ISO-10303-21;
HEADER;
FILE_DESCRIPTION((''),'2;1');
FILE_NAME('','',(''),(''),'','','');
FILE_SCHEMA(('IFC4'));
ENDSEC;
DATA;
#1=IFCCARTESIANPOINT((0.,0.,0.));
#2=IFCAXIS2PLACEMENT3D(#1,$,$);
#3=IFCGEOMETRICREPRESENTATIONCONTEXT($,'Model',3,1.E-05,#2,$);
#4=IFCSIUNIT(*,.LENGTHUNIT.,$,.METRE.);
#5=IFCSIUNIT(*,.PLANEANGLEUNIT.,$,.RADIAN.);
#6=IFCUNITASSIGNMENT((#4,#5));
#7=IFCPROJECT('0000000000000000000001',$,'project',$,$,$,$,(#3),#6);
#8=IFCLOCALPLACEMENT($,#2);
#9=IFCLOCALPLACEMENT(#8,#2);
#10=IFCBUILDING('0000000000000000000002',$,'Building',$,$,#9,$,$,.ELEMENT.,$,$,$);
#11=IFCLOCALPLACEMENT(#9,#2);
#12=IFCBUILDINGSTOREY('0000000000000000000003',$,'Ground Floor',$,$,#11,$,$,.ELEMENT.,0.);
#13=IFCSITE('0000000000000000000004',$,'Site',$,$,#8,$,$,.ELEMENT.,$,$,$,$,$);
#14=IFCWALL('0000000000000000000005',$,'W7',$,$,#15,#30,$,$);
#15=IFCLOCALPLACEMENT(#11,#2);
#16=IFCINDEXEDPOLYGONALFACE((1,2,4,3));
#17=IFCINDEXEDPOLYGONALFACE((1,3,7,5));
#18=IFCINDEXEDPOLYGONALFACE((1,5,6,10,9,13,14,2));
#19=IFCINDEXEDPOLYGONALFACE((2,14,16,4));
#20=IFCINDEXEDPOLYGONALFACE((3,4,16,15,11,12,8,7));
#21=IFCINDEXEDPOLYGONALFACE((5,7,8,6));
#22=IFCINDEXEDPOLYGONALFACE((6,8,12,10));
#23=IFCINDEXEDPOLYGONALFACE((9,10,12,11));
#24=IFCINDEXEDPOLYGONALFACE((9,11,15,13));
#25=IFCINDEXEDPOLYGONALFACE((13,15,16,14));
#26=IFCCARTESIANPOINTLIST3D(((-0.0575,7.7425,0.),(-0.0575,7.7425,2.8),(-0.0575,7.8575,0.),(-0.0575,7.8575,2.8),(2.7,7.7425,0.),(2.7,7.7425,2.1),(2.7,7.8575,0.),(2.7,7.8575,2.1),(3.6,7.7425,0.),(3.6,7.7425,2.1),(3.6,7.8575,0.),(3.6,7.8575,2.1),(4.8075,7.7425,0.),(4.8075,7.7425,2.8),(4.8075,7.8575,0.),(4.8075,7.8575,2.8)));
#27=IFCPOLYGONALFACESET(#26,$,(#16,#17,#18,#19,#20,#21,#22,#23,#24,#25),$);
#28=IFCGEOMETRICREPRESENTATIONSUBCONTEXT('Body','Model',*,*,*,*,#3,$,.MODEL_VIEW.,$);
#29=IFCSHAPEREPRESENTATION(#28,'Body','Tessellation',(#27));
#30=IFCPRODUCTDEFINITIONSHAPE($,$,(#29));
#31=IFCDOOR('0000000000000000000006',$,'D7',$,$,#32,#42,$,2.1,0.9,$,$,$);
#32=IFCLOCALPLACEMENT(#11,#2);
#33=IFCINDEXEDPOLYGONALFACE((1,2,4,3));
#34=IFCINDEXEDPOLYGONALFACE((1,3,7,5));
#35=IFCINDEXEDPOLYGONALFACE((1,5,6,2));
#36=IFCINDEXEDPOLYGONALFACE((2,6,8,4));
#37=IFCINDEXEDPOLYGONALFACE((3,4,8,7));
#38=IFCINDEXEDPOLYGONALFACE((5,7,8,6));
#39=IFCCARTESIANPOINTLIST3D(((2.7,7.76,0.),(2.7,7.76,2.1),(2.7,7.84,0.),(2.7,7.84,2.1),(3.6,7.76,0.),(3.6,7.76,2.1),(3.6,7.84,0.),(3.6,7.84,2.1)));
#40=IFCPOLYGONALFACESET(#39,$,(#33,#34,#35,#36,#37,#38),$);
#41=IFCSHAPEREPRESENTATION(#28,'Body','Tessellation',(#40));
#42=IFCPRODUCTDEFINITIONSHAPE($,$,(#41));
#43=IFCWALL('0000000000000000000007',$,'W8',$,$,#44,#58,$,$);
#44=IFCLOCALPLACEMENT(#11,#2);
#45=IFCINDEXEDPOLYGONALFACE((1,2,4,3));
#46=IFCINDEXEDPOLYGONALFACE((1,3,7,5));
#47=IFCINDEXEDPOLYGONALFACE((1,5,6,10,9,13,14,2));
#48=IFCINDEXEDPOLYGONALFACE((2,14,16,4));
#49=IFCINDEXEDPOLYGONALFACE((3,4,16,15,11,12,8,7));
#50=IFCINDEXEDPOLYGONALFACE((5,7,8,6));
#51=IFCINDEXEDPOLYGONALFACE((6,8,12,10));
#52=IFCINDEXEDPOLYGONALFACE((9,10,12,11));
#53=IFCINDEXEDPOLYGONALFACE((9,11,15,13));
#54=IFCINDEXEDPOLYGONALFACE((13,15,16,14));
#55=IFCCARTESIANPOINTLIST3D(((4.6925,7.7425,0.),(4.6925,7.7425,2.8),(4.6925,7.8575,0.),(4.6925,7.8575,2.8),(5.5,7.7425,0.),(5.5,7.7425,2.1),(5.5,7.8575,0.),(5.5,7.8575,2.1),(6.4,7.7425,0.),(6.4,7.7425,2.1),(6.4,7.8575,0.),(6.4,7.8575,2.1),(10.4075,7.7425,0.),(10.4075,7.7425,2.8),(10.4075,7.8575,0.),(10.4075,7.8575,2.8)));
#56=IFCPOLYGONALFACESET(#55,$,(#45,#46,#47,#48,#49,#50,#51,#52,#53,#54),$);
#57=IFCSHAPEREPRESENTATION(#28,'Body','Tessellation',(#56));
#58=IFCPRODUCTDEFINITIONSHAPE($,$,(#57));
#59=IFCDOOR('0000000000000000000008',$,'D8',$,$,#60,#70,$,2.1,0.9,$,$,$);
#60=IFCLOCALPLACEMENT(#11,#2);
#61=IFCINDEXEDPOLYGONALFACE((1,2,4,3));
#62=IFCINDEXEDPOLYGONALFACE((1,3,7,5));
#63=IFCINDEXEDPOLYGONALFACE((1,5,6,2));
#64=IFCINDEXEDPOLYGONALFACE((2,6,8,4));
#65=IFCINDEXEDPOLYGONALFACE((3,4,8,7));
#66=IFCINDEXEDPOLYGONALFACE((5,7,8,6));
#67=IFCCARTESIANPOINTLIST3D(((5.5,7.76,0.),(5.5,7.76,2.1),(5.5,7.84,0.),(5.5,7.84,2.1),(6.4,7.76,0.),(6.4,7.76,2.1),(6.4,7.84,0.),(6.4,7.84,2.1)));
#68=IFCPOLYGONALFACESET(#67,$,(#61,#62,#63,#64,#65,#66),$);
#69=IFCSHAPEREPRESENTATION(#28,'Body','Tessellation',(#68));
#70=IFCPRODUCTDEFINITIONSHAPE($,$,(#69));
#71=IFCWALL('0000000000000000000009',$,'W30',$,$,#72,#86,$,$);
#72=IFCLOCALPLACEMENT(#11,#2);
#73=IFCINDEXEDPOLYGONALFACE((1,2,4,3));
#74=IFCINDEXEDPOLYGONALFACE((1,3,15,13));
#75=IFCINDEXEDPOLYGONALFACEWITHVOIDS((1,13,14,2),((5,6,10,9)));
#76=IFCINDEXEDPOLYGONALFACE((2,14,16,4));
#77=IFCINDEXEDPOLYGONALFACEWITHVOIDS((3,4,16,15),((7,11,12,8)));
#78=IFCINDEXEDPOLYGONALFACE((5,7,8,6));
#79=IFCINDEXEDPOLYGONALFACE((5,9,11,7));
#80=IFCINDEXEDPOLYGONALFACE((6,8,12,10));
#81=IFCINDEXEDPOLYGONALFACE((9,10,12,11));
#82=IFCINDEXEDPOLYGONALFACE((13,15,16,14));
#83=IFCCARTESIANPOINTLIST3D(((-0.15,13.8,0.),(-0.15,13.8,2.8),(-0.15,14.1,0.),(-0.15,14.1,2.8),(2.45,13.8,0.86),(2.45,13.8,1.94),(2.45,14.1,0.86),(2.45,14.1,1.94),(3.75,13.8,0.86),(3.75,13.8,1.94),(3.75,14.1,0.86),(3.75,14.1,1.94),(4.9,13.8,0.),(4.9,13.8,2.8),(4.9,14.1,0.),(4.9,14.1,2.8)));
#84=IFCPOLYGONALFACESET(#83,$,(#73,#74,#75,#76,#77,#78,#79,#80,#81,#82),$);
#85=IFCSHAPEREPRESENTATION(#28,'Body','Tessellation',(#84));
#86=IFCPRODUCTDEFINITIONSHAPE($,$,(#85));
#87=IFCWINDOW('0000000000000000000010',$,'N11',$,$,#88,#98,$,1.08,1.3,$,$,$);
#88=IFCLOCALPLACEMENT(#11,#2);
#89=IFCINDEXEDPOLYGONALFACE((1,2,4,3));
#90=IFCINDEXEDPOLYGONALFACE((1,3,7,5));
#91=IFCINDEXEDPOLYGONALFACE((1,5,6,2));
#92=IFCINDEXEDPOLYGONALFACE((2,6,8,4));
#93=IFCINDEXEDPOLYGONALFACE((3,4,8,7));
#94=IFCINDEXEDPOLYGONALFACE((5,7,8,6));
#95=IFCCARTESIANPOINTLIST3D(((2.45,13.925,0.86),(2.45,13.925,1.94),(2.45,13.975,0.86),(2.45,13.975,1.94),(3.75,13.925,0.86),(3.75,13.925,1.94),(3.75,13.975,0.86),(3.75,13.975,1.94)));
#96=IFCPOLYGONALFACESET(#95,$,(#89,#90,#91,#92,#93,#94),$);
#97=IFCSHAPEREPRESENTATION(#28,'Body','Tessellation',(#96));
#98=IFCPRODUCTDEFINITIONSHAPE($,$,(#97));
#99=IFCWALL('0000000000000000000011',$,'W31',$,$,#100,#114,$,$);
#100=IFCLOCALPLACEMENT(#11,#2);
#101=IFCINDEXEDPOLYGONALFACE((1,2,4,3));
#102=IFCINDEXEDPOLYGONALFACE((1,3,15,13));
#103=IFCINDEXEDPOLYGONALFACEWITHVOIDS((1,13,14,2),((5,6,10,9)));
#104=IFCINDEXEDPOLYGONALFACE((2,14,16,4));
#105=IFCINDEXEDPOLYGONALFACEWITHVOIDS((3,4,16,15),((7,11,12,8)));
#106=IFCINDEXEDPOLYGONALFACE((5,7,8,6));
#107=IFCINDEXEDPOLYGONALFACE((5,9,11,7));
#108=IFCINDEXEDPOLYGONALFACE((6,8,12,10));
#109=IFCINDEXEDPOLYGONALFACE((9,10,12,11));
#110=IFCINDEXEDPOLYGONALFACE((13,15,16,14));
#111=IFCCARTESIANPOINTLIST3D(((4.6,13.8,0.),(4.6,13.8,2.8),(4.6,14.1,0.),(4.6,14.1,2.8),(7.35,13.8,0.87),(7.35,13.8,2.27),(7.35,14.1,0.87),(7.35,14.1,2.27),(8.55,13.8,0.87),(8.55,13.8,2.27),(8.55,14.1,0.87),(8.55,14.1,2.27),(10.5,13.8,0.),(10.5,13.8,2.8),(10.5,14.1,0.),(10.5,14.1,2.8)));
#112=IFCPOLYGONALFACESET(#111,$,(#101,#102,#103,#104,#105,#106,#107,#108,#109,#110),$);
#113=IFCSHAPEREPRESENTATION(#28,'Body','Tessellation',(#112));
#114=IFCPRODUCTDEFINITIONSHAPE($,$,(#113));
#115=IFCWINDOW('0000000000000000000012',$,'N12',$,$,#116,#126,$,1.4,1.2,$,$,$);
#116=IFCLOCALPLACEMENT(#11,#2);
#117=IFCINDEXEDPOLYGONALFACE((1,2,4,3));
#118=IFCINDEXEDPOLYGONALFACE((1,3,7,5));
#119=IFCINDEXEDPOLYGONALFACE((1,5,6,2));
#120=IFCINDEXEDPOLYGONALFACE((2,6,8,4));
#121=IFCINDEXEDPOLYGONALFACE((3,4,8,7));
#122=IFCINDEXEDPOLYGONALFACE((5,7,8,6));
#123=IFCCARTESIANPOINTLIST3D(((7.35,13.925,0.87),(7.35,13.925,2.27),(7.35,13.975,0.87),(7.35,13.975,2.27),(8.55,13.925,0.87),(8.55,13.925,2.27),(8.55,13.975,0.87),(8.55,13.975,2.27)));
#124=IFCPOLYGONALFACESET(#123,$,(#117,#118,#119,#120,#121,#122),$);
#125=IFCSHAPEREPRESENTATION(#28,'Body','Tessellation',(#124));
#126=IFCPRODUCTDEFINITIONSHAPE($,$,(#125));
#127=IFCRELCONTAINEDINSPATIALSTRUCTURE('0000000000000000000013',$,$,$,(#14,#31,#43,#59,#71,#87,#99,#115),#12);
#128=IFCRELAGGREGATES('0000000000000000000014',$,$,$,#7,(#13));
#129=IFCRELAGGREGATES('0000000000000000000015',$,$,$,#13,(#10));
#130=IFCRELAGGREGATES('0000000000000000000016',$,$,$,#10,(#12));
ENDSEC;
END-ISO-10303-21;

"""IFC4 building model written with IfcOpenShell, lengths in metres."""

from ifc_helpers import new_model, si_unit, frame, frame_2d, origin, origin_2d, place, context, subcontext, project, spatial, rectangle, extrude, element, fill, save


model = new_model("IFC4")

# Units and contexts
model_context = context("Model", 3, precision=1e-05, world=origin())
body_context = subcontext(model_context, "Body", "Model", "MODEL_VIEW")
ifc_project = project(units=[si_unit("LENGTHUNIT", "METRE"), si_unit("PLANEANGLEUNIT", "RADIAN")], contexts=[model_context])

# Site, building, storey
site_placement = place(None, origin())
site = spatial("IfcSite", under=ifc_project, at=site_placement, Name="Site", CompositionType="ELEMENT")
building_placement = place(site_placement, origin())
building = spatial("IfcBuilding", under=site, at=building_placement, Name="Building", CompositionType="ELEMENT")
storey_placement = place(building_placement, origin())
storey = spatial("IfcBuildingStorey", under=building, at=storey_placement, Name="Ground Floor", CompositionType="ELEMENT", Elevation=0.0)

# Walls, openings, doors
wall_1_placement = place(storey_placement, frame((0.0, 7.8, 0.0), x_axis=(1.0, 0.0, 0.0)))
wall_1 = element("IfcWall", 1, at=wall_1_placement, inside=storey, Name="W7", context=body_context, shape_type="SweptSolid", body=[
    extrude(rectangle(XDim=4.865, YDim=0.115, at=frame_2d((2.375, 0.0))), origin(), (0.0, 0.0, 1.0), 2.8),
])
opening_1_placement = place(wall_1_placement, frame((3.15, 0.0, 0.0)))
opening_1 = element("IfcOpeningElement", 2, at=opening_1_placement, cuts=wall_1, context=body_context, shape_type="SweptSolid", body=[
    extrude(rectangle(XDim=0.9, YDim=0.215, at=origin_2d()), origin(), (0.0, 0.0, 1.0), 2.1),
])
door_1_placement = place(opening_1_placement, origin())
door_1 = element("IfcDoor", 3, at=door_1_placement, inside=storey, Name="D7", OverallHeight=2.1, OverallWidth=0.9, context=body_context, shape_type="SweptSolid", body=[
    extrude(rectangle(XDim=0.9, YDim=0.08, at=origin_2d()), origin(), (0.0, 0.0, 1.0), 2.1),
])
fill(opening_1, door_1)
wall_2_placement = place(storey_placement, frame((4.75, 7.8, 0.0), x_axis=(1.0, 0.0, 0.0)))
wall_2 = element("IfcWall", 4, at=wall_2_placement, inside=storey, Name="W8", context=body_context, shape_type="SweptSolid", body=[
    extrude(rectangle(XDim=5.715, YDim=0.115, at=frame_2d((2.8, 0.0))), origin(), (0.0, 0.0, 1.0), 2.8),
])
opening_2_placement = place(wall_2_placement, frame((1.2, 0.0, 0.0)))
opening_2 = element("IfcOpeningElement", 5, at=opening_2_placement, cuts=wall_2, context=body_context, shape_type="SweptSolid", body=[
    extrude(rectangle(XDim=0.9, YDim=0.215, at=origin_2d()), origin(), (0.0, 0.0, 1.0), 2.1),
])
door_2_placement = place(opening_2_placement, origin())
door_2 = element("IfcDoor", 6, at=door_2_placement, inside=storey, Name="D8", OverallHeight=2.1, OverallWidth=0.9, context=body_context, shape_type="SweptSolid", body=[
    extrude(rectangle(XDim=0.9, YDim=0.08, at=origin_2d()), origin(), (0.0, 0.0, 1.0), 2.1),
])
fill(opening_2, door_2)

# Walls, openings, windows
wall_3_placement = place(storey_placement, frame((0.0, 13.95, 0.0), x_axis=(1.0, 0.0, 0.0)))
wall_3 = element("IfcWall", 7, at=wall_3_placement, inside=storey, Name="W30", context=body_context, shape_type="SweptSolid", body=[
    extrude(rectangle(XDim=5.05, YDim=0.3, at=frame_2d((2.375, 0.0))), origin(), (0.0, 0.0, 1.0), 2.8),
])
opening_3_placement = place(wall_3_placement, frame((3.1, 0.0, 0.86)))
opening_3 = element("IfcOpeningElement", 8, at=opening_3_placement, cuts=wall_3, context=body_context, shape_type="SweptSolid", body=[
    extrude(rectangle(XDim=1.3, YDim=0.4, at=origin_2d()), origin(), (0.0, 0.0, 1.0), 1.08),
])
window_1_placement = place(opening_3_placement, origin())
window_1 = element("IfcWindow", 9, at=window_1_placement, inside=storey, Name="N11", OverallHeight=1.08, OverallWidth=1.3, context=body_context, shape_type="SweptSolid", body=[
    extrude(rectangle(XDim=1.3, YDim=0.05, at=origin_2d()), origin(), (0.0, 0.0, 1.0), 1.08),
])
fill(opening_3, window_1)
wall_4_placement = place(storey_placement, frame((4.75, 13.95, 0.0), x_axis=(1.0, 0.0, 0.0)))
wall_4 = element("IfcWall", 10, at=wall_4_placement, inside=storey, Name="W31", context=body_context, shape_type="SweptSolid", body=[
    extrude(rectangle(XDim=5.9, YDim=0.3, at=frame_2d((2.8, 0.0))), origin(), (0.0, 0.0, 1.0), 2.8),
])
opening_4_placement = place(wall_4_placement, frame((3.2, 0.0, 0.87)))
opening_4 = element("IfcOpeningElement", 11, at=opening_4_placement, cuts=wall_4, context=body_context, shape_type="SweptSolid", body=[
    extrude(rectangle(XDim=1.2, YDim=0.4, at=origin_2d()), origin(), (0.0, 0.0, 1.0), 1.4),
])
window_2_placement = place(opening_4_placement, origin())
window_2 = element("IfcWindow", 12, at=window_2_placement, inside=storey, Name="N12", OverallHeight=1.4, OverallWidth=1.2, context=body_context, shape_type="SweptSolid", body=[
    extrude(rectangle(XDim=1.2, YDim=0.05, at=origin_2d()), origin(), (0.0, 0.0, 1.0), 1.4),
])
fill(opening_4, window_2)

save(model, "model.ifc")
